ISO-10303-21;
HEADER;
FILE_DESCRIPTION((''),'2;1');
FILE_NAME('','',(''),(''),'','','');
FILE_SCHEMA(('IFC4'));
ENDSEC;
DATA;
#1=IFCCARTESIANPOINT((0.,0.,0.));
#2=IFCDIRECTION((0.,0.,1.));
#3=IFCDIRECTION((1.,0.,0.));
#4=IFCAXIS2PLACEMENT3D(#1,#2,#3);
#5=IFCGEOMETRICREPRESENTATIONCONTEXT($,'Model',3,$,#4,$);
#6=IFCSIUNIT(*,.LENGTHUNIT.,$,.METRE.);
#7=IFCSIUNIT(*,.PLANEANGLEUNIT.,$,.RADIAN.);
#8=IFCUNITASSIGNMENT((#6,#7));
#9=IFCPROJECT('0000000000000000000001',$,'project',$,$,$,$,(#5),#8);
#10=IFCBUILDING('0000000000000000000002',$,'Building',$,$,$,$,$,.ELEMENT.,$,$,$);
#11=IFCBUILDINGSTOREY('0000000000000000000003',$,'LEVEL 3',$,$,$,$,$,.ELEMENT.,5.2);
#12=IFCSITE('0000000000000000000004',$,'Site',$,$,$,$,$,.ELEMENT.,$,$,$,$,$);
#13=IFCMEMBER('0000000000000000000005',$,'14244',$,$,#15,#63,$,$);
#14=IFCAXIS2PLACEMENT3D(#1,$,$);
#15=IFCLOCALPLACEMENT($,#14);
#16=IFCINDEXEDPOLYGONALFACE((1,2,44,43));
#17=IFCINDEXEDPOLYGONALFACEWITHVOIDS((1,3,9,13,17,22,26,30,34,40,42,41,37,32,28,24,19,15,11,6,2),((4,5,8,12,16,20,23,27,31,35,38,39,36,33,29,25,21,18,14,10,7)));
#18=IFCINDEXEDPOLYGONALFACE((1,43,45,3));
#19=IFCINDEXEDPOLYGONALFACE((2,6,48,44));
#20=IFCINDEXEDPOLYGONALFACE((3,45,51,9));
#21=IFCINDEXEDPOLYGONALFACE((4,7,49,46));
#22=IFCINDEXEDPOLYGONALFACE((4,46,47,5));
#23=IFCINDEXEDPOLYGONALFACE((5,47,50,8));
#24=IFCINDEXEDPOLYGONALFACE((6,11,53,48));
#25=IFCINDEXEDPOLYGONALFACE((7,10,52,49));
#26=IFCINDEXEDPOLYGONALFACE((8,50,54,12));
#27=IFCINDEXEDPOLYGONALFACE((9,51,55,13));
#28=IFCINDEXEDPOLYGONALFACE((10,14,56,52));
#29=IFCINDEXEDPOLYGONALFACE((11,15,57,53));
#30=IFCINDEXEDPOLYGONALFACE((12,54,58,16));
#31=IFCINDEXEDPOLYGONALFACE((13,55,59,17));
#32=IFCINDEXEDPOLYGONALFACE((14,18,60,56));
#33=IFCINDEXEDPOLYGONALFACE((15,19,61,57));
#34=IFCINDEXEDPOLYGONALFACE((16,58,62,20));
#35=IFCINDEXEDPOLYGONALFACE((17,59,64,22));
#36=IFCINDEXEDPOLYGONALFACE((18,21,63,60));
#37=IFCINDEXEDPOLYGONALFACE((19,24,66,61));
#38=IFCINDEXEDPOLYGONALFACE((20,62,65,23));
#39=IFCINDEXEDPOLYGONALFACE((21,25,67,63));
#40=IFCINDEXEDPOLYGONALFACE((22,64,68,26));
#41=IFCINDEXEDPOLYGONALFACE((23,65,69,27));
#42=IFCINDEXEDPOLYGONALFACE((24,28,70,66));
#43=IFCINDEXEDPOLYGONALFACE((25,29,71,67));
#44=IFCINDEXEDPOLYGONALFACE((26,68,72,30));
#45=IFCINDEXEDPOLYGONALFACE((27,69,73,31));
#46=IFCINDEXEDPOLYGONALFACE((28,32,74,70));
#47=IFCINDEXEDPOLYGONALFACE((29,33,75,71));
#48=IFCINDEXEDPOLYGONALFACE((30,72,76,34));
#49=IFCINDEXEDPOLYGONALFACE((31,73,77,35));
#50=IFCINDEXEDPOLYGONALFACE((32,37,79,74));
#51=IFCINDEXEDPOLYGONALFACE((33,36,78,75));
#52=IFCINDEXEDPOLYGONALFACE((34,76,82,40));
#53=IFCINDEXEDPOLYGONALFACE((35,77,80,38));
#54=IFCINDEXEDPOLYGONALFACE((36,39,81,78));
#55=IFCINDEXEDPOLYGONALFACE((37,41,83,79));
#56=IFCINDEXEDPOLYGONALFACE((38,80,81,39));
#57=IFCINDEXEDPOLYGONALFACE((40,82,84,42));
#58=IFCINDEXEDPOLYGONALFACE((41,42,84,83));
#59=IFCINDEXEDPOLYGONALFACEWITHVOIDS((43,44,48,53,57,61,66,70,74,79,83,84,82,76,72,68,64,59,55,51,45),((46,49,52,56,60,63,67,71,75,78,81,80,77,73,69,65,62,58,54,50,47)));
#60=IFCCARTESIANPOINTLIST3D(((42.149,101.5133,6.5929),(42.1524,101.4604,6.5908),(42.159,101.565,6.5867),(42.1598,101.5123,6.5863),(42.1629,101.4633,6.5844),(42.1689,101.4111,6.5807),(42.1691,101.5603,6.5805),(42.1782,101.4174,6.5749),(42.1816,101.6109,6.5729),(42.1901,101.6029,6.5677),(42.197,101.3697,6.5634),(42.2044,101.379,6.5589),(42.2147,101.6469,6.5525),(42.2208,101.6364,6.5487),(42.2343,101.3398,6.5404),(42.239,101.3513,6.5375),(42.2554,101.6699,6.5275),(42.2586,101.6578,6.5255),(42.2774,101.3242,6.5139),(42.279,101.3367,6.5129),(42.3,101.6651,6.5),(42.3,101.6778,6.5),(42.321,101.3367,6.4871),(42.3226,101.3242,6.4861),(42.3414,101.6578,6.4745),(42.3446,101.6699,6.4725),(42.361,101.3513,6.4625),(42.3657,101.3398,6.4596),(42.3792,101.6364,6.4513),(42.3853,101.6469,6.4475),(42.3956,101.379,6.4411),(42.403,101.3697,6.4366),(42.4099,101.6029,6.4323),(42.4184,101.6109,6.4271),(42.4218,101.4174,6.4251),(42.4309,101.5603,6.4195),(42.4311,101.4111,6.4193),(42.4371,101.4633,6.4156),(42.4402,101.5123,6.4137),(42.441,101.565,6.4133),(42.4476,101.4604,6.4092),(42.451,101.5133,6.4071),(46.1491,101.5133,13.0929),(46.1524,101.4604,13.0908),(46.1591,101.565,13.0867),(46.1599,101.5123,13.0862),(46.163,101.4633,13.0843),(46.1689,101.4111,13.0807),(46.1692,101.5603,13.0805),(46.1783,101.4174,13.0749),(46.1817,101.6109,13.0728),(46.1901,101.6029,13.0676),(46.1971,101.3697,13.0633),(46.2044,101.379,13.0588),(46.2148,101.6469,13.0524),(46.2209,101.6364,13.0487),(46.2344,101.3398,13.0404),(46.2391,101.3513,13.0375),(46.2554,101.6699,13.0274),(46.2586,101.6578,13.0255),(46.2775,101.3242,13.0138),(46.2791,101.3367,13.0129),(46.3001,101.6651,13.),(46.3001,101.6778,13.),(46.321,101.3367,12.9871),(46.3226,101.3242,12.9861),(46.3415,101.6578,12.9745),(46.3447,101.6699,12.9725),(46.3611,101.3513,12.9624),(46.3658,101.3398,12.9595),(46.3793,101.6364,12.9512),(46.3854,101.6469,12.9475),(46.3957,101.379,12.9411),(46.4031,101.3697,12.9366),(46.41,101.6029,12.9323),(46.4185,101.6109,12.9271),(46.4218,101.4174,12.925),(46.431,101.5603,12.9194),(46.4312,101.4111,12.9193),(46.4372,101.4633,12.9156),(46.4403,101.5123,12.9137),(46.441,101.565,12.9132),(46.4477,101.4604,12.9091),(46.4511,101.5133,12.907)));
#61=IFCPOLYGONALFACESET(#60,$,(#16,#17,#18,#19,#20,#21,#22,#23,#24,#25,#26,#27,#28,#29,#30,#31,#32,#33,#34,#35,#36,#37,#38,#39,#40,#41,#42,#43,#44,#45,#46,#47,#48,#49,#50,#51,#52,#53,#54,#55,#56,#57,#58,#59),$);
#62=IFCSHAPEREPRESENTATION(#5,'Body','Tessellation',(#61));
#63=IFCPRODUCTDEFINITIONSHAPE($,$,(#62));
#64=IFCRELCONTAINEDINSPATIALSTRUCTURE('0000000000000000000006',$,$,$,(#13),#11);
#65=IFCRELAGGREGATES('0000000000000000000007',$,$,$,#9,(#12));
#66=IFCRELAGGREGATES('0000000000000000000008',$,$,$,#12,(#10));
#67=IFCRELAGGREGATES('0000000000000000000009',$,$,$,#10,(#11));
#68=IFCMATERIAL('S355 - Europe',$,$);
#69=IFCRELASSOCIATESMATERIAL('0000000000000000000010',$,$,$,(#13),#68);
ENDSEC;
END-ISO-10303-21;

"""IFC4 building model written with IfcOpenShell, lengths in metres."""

from ifc_helpers import new_model, si_unit, frame, origin_with_axes, origin_2d_with_axis, place, context, project, spatial, hollow_circle, extrude, material, material_profile, profile_set, profile_usage, element, save


model = new_model("IFC4")

# Units and contexts
model_context = context("Model", 3, world=origin_with_axes())
ifc_project = project(units=[si_unit("LENGTHUNIT", "METRE"), si_unit("PLANEANGLEUNIT", "RADIAN")], contexts=[model_context])

# Site, building, storey
site = spatial("IfcSite", under=ifc_project, Name="Site", CompositionType="ELEMENT")
building = spatial("IfcBuilding", under=site, Name="Building", CompositionType="ELEMENT")
storey = spatial("IfcBuildingStorey", under=building, Name="LEVEL 3", CompositionType="ELEMENT", Elevation=5.2)

# Shared definitions
ifc_material = material(Name="S355 - Europe")

# Member
ifc_material_profile_1 = material_profile(ifc_material, hollow_circle(Radius=0.1778, WallThickness=0.0127, at=origin_2d_with_axis()))
ifc_profile_set_1 = profile_set([ifc_material_profile_1])
ifc_profile_usage_1 = profile_usage(ifc_profile_set_1, cardinal=10)
member_1_placement = place(None, frame((42.3, 101.5, 6.5), z_axis=(0.524107, 0.0, 0.851652), x_axis=(0.0, 1.0, 0.0)))
element("IfcMember", 1, at=member_1_placement, inside=storey, material=ifc_profile_usage_1, Name="14244", context=model_context, shape_type="SweptSolid", body=[
    extrude(hollow_circle(Radius=0.1778, WallThickness=0.0127, at=origin_2d_with_axis()), origin_with_axes(), (0.0, 0.0, 1.0), 7.6322),
])

save(model, "model.ifc")
